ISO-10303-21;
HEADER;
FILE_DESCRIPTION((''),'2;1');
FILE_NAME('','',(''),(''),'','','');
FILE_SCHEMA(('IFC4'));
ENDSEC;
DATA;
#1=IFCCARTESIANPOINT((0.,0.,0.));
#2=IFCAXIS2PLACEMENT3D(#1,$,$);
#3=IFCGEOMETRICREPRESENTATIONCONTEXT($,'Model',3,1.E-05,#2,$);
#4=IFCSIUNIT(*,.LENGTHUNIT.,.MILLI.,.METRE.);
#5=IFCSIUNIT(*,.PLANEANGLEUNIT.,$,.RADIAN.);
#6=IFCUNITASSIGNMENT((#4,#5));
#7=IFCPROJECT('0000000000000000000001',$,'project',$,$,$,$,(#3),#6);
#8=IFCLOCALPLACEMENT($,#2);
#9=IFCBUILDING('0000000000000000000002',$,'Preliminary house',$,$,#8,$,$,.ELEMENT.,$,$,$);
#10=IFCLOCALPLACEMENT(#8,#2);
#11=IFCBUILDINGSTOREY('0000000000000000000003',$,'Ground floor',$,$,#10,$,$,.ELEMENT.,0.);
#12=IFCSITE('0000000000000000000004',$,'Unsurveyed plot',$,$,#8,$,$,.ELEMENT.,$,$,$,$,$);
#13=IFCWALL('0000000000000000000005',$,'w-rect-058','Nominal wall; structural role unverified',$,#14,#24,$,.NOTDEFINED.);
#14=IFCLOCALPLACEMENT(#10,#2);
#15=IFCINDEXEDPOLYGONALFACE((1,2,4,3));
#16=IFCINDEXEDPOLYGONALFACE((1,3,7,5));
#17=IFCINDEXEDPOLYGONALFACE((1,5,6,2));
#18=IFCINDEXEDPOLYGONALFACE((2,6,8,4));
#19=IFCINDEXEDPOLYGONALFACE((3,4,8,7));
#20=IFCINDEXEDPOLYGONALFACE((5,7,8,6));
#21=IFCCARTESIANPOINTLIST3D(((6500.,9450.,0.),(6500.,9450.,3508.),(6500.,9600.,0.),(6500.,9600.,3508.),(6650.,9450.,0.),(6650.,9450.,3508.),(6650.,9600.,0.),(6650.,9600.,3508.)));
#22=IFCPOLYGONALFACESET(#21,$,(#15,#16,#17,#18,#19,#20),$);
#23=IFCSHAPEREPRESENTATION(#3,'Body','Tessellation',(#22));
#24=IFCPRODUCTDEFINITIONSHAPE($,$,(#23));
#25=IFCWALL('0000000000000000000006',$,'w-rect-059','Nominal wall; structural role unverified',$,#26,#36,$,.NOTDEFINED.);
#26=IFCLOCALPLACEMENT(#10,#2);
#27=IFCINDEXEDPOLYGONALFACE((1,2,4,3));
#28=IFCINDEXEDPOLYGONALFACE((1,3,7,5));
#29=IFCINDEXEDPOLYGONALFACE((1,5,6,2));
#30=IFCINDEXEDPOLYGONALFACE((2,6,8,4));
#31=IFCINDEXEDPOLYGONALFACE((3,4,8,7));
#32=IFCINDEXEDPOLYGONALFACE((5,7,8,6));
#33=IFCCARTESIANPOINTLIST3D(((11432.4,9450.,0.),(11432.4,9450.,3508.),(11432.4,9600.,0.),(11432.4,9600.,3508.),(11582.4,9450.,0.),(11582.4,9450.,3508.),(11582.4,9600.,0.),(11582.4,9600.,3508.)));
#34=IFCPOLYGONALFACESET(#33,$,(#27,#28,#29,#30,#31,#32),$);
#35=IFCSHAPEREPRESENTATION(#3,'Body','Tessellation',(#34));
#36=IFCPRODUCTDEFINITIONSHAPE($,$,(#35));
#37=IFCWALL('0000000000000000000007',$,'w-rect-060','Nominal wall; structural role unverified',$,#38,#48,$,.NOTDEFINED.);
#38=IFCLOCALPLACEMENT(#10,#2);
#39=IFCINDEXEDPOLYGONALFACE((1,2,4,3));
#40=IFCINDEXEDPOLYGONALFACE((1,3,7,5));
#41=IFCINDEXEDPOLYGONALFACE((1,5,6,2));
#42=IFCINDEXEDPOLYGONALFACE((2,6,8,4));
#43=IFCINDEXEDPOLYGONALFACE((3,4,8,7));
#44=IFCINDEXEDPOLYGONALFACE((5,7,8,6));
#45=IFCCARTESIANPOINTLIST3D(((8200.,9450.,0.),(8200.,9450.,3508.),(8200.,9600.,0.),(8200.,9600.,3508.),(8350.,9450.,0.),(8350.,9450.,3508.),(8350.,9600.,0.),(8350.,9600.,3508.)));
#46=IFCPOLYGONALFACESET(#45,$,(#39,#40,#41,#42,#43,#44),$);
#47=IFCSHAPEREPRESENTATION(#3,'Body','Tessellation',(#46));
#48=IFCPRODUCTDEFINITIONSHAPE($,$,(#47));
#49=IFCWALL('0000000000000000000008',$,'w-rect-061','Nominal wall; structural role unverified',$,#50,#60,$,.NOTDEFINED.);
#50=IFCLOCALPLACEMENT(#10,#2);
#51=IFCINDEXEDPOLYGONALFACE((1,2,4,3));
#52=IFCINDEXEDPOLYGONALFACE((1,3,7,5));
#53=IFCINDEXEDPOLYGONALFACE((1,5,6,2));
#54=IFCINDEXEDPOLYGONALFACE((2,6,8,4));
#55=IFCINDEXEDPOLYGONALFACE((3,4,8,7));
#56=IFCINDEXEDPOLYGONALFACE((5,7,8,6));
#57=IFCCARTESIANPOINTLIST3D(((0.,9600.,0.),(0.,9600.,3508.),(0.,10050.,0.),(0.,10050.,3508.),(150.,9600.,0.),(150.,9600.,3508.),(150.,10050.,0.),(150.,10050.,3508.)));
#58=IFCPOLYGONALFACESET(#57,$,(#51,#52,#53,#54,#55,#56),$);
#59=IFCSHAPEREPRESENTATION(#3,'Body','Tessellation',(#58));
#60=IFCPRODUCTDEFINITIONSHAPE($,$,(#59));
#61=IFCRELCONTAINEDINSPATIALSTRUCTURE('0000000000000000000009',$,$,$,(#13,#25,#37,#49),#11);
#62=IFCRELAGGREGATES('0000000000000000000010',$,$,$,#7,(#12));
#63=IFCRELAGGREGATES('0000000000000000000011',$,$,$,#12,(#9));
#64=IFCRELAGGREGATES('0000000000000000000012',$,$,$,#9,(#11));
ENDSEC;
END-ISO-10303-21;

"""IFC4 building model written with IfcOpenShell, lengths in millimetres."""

from ifc_helpers import new_model, si_unit, origin, place, context, project, spatial, polyline, outline, extrude, element, save


model = new_model("IFC4")

# Units and contexts
model_context = context("Model", 3, precision=1e-05, world=origin())
ifc_project = project(units=[si_unit("LENGTHUNIT", "METRE", prefix="MILLI"), si_unit("PLANEANGLEUNIT", "RADIAN")], contexts=[model_context])

# Site, building, storey
placement_1 = place(None, origin())
site = spatial("IfcSite", under=ifc_project, at=placement_1, Name="Unsurveyed plot", CompositionType="ELEMENT")
building = spatial("IfcBuilding", under=site, at=placement_1, Name="Preliminary house", CompositionType="ELEMENT")
placement_2 = place(placement_1, origin())
storey = spatial("IfcBuildingStorey", under=building, at=placement_2, Name="Ground floor", CompositionType="ELEMENT", Elevation=0.0)

# Walls
element("IfcWall", 1, at=placement_2, inside=storey, Name="w-rect-058", Description="Nominal wall; structural role unverified", PredefinedType="NOTDEFINED", context=model_context, shape_type="SweptSolid", body=[
    extrude(outline(polyline([(6500.0, 9450.0), (6650.0, 9450.0), (6650.0, 9600.0), (6500.0, 9600.0), (6500.0, 9450.0)])), origin(), (0.0, 0.0, 1.0), 3508.0),
])
element("IfcWall", 2, at=placement_2, inside=storey, Name="w-rect-059", Description="Nominal wall; structural role unverified", PredefinedType="NOTDEFINED", context=model_context, shape_type="SweptSolid", body=[
    extrude(outline(polyline([(11432.4, 9450.0), (11582.4, 9450.0), (11582.4, 9600.0), (11432.4, 9600.0), (11432.4, 9450.0)])), origin(), (0.0, 0.0, 1.0), 3508.0),
])
element("IfcWall", 3, at=placement_2, inside=storey, Name="w-rect-060", Description="Nominal wall; structural role unverified", PredefinedType="NOTDEFINED", context=model_context, shape_type="SweptSolid", body=[
    extrude(outline(polyline([(8200.0, 9450.0), (8350.0, 9450.0), (8350.0, 9600.0), (8200.0, 9600.0), (8200.0, 9450.0)])), origin(), (0.0, 0.0, 1.0), 3508.0),
])
element("IfcWall", 4, at=placement_2, inside=storey, Name="w-rect-061", Description="Nominal wall; structural role unverified", PredefinedType="NOTDEFINED", context=model_context, shape_type="SweptSolid", body=[
    extrude(outline(polyline([(0.0, 9600.0), (150.0, 9600.0), (150.0, 10050.0), (0.0, 10050.0), (0.0, 9600.0)])), origin(), (0.0, 0.0, 1.0), 3508.0),
])

save(model, "model.ifc")
